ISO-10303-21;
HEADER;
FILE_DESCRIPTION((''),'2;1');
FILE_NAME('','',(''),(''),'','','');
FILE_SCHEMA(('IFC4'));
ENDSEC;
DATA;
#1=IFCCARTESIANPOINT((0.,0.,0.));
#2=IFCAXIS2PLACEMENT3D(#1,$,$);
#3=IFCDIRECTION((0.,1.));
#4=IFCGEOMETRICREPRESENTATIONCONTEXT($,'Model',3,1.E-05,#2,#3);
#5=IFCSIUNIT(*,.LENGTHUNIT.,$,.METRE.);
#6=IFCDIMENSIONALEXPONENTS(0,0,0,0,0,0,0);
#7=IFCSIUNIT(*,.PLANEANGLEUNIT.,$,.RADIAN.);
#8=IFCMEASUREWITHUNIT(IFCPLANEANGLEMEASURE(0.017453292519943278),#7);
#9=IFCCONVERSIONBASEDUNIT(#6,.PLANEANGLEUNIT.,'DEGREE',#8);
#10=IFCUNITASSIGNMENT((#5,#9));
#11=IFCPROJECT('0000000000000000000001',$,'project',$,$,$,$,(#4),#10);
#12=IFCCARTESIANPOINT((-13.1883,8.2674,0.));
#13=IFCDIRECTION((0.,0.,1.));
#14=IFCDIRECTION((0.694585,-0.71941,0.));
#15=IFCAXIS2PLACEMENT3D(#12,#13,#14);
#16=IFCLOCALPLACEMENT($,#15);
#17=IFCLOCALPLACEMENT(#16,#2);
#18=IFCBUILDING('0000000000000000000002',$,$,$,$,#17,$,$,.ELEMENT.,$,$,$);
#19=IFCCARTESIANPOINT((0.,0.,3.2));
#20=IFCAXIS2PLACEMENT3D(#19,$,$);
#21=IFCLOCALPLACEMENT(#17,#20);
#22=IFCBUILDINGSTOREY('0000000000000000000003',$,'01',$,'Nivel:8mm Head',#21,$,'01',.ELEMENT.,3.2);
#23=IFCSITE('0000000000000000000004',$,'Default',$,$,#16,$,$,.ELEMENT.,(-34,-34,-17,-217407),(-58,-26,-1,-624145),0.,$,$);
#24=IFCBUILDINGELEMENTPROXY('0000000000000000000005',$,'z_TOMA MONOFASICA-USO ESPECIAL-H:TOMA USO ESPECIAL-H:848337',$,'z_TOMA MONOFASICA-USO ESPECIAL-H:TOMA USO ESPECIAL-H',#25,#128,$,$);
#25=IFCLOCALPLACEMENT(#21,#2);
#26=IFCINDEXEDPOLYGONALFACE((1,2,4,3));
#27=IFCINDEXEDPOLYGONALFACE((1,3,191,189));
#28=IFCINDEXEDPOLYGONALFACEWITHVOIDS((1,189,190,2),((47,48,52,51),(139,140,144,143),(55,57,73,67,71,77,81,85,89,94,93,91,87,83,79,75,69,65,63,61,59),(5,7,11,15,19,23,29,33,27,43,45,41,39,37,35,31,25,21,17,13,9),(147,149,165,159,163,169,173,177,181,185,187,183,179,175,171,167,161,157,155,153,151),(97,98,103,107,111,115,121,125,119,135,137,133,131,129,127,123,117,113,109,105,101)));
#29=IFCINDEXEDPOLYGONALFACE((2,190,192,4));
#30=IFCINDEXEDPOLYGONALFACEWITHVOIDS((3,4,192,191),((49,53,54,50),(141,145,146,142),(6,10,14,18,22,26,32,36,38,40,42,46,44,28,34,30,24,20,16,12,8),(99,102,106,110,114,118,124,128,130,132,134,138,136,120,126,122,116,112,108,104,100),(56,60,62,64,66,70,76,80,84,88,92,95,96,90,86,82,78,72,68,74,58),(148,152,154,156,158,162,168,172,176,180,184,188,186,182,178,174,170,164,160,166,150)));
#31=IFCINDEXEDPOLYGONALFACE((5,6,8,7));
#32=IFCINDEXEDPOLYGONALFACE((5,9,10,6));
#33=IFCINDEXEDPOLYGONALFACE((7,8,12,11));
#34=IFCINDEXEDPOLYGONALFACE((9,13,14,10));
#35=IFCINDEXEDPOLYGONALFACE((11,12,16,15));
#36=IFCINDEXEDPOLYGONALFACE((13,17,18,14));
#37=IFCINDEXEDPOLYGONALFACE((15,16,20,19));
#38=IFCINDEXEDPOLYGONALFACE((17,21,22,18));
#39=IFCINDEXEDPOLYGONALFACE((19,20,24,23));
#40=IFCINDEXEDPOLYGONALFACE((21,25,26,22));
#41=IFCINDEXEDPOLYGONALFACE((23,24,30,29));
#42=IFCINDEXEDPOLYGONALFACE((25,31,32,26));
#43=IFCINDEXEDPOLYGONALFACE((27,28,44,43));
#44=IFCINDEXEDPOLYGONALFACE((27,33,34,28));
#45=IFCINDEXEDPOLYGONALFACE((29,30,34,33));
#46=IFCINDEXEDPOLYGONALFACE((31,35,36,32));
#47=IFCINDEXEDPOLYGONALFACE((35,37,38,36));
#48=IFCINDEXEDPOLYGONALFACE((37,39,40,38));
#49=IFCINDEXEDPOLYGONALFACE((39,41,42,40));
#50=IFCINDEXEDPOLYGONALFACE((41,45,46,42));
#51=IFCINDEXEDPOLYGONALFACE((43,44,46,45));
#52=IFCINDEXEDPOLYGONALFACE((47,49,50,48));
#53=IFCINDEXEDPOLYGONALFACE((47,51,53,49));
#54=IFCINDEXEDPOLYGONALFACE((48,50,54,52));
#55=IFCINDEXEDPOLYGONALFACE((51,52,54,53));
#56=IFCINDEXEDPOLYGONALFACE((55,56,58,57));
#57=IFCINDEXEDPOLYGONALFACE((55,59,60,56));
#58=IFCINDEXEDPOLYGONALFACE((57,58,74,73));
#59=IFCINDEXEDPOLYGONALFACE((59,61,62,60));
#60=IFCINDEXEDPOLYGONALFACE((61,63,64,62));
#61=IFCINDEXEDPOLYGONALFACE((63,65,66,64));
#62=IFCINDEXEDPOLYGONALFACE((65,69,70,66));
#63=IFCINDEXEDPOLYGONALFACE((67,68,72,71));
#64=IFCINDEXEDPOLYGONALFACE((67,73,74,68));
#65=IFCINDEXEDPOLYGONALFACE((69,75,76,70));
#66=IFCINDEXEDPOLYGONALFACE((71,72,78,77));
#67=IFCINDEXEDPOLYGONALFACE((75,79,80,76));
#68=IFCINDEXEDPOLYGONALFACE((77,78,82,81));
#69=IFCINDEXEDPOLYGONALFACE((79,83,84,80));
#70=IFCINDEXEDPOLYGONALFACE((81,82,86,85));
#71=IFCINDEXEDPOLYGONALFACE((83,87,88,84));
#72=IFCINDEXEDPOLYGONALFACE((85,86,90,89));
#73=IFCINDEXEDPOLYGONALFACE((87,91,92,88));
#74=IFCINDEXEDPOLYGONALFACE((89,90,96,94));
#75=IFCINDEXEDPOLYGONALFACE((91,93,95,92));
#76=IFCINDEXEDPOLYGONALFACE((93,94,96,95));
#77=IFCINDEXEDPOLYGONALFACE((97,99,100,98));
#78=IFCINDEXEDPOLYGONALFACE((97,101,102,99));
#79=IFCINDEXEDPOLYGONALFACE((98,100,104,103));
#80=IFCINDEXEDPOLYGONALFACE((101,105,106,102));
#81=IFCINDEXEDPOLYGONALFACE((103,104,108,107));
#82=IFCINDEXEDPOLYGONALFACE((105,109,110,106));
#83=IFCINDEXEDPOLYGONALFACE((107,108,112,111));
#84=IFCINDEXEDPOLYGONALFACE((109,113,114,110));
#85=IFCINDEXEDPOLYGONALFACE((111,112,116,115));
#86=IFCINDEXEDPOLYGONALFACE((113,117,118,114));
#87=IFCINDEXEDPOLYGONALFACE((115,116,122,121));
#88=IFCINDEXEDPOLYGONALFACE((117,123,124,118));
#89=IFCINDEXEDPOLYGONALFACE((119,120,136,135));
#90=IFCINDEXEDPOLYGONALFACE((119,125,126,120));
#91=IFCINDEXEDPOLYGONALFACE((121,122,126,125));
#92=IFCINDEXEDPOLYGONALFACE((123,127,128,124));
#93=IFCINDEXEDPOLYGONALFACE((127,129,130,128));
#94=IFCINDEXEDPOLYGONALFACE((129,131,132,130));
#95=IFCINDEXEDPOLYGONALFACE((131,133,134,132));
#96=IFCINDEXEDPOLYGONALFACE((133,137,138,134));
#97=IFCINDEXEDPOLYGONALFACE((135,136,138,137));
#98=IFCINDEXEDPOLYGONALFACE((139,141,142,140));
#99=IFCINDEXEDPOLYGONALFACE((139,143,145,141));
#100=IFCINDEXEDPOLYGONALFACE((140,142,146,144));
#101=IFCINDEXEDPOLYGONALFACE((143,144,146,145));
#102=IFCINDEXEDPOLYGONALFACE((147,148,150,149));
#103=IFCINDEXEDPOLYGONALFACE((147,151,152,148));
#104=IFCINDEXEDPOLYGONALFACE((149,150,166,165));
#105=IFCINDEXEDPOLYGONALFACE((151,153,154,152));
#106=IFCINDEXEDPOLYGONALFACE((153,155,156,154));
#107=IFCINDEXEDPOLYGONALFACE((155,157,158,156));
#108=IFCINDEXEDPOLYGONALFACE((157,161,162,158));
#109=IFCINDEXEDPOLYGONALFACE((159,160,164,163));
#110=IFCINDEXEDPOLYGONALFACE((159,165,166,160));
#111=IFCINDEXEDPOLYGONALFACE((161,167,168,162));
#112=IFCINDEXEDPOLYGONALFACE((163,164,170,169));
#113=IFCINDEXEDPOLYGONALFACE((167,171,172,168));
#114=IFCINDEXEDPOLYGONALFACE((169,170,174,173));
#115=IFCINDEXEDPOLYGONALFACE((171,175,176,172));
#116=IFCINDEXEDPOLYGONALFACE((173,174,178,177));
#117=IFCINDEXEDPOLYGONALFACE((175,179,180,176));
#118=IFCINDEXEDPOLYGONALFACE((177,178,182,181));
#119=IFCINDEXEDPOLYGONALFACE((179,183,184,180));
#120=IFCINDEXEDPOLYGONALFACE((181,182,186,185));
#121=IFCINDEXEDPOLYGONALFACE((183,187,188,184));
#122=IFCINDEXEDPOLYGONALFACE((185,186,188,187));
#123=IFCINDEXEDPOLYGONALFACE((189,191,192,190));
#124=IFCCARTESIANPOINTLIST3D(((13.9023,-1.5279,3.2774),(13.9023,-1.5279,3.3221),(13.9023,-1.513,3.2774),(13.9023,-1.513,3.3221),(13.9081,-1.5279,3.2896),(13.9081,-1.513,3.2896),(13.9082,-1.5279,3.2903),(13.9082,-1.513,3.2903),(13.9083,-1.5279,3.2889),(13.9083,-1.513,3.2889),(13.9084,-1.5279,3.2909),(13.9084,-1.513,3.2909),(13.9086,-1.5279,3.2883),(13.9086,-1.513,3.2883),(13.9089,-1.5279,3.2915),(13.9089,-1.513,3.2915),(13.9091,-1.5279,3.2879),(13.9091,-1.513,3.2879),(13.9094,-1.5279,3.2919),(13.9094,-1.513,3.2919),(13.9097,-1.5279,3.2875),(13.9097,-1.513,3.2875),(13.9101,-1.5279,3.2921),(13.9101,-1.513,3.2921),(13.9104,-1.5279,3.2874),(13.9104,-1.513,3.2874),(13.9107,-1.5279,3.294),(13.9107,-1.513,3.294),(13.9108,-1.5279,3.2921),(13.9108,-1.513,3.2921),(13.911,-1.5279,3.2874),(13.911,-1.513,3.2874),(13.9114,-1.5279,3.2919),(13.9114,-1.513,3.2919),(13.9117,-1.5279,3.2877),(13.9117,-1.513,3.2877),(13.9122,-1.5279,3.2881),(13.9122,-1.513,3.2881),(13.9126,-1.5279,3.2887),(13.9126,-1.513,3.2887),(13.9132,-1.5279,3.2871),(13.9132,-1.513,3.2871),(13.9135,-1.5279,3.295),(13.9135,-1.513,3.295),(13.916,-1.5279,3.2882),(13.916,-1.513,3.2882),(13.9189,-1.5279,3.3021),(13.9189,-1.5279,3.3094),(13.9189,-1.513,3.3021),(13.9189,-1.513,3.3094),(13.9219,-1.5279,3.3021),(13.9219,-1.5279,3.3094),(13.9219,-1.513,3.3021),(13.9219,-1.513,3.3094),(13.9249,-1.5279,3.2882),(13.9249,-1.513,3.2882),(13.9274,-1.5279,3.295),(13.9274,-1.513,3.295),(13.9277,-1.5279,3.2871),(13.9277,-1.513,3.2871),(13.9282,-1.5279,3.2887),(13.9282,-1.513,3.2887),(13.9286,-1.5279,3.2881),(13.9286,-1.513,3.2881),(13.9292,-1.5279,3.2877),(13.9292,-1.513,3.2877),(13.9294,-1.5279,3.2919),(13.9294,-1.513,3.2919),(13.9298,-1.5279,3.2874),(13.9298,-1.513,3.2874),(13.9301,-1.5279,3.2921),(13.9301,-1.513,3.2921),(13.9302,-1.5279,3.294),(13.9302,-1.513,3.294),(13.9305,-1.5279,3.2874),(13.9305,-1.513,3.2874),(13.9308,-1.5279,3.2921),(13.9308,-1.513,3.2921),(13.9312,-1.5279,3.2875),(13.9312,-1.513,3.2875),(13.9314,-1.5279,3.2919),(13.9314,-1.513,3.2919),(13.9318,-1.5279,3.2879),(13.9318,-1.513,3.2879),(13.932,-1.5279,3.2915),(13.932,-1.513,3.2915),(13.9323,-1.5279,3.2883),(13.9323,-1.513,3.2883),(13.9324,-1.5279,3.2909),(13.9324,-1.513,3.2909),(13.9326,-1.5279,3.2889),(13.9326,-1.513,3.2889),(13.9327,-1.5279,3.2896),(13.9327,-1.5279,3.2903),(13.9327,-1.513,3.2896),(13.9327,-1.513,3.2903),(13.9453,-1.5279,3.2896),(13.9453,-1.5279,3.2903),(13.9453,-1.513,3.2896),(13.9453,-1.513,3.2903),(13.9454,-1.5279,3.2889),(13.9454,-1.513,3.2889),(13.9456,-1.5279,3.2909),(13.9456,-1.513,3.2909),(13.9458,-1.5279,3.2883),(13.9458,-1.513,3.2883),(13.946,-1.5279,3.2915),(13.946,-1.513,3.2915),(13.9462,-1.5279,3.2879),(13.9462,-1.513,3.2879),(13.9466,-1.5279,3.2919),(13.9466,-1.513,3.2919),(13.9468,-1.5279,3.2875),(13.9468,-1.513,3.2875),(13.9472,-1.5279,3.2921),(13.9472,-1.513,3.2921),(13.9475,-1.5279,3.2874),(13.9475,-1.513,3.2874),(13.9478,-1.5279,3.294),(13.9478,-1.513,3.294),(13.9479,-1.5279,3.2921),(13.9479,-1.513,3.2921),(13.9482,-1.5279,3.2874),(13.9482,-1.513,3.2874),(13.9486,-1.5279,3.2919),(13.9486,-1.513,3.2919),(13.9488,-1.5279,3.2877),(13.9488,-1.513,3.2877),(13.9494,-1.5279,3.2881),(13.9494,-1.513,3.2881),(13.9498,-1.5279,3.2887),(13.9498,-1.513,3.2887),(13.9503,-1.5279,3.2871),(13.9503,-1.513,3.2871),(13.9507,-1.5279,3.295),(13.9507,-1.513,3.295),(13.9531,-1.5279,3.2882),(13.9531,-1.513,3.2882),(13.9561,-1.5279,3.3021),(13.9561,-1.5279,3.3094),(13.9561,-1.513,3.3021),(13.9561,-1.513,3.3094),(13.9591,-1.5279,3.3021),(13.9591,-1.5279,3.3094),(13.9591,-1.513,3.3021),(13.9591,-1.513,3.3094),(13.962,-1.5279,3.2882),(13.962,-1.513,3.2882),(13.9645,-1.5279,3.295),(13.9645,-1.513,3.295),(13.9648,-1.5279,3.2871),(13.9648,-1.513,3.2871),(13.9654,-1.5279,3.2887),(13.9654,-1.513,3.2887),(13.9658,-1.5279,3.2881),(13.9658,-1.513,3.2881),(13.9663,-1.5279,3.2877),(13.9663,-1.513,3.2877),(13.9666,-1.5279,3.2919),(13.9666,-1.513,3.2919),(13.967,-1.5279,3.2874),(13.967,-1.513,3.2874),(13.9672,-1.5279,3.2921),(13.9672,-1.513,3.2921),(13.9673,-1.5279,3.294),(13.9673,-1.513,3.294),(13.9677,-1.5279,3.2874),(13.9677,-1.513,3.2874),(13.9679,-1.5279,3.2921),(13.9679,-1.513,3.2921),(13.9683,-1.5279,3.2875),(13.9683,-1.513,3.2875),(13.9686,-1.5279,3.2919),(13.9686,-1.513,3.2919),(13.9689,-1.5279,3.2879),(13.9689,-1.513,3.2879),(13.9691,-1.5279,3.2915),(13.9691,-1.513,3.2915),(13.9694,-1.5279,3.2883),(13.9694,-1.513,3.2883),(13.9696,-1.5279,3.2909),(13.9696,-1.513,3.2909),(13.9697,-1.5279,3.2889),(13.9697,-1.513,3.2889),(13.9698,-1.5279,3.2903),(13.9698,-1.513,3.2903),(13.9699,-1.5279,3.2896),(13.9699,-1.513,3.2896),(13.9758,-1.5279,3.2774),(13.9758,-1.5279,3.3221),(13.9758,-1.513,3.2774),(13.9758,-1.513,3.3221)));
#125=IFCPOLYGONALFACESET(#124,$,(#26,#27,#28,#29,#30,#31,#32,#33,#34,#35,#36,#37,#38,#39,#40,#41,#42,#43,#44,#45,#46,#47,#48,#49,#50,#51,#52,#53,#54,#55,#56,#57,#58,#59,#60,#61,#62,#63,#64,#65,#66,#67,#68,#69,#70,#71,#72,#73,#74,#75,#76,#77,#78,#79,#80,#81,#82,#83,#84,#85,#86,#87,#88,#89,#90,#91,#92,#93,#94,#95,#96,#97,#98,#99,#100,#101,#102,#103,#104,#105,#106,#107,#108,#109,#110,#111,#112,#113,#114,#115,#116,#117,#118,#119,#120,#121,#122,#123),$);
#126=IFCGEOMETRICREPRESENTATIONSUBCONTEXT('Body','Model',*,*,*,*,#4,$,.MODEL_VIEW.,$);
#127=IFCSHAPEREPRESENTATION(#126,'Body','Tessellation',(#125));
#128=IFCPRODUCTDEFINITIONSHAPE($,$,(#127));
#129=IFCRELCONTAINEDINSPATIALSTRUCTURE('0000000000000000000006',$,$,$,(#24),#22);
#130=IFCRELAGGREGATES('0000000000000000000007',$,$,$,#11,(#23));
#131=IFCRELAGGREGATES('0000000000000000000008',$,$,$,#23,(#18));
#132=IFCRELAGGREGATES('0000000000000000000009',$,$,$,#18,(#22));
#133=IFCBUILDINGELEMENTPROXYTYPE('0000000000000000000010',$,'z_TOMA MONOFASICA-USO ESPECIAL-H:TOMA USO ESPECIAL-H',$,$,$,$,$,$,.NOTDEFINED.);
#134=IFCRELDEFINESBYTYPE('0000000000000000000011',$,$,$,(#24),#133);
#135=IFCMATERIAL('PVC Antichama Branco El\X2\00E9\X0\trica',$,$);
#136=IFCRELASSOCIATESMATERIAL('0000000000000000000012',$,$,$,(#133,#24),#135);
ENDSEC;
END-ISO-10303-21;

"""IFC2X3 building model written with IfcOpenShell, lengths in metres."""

from ifc_helpers import new_model, entity, si_unit, converted_unit, direction, frame, frame_2d, origin, place, context, subcontext, project, spatial, polyline, circle_curve, parameter, trimmed, segment, composite_curve, outline, extrude, source, transform, mapped, material, type_object, type_shapes, element, save


model = new_model("IFC2X3")

# Units and contexts
model_context = context("Model", 3, precision=1e-05, world=origin(), true_north=direction((0.0, 1.0)))
body_context = subcontext(model_context, "Body", "Model", "MODEL_VIEW")
ifc_project = project(units=[si_unit("LENGTHUNIT", "METRE"), converted_unit("PLANEANGLEUNIT", "DEGREE", entity("IfcPlaneAngleMeasure", 0.017453292519943278), si_unit("PLANEANGLEUNIT", "RADIAN"), dimensions=[0, 0, 0, 0, 0, 0, 0])], contexts=[model_context])

# Site, building, storey
site_placement = place(None, frame((-13.1883, 8.2674, 0.0), z_axis=(0.0, 0.0, 1.0), x_axis=(0.694585, -0.71941, 0.0)))
site = spatial("IfcSite", under=ifc_project, at=site_placement, Name="Default", CompositionType="ELEMENT", RefLatitude=(-34, -34, -17, -217407), RefLongitude=(-58, -26, -1, -624145), RefElevation=0.0)
building_placement = place(site_placement, origin())
building = spatial("IfcBuilding", under=site, at=building_placement, CompositionType="ELEMENT")
storey_placement = place(building_placement, frame((0.0, 0.0, 3.2)))
storey = spatial("IfcBuildingStorey", under=building, at=storey_placement, Name="01", ObjectType="Nivel:8mm Head", LongName="01", CompositionType="ELEMENT", Elevation=3.2)

# Building element proxy
ifc_material_1 = material(Name="PVC Antichama Branco Elétrica")
building_element_proxy_type_1 = type_object("IfcBuildingElementProxyType", Name="z_TOMA MONOFASICA-USO ESPECIAL-H:TOMA USO ESPECIAL-H", PredefinedType="NOTDEFINED", material=ifc_material_1)
shared_shape_1 = source(origin(), body_context, "Body", "SweptSolid", [
    extrude(outline(polyline([(-0.0368, -0.0223), (0.0368, -0.0223), (0.0368, 0.0223), (-0.0368, 0.0223), (-0.0368, -0.0223)]), holes=[composite_curve([segment(polyline([(0.0141, 0.0115), (0.0116, 0.0047)]), True, "CONTINUOUS"), segment(polyline([(0.0116, 0.0047), (0.0088, 0.0057)]), True, "CONTINUOUS"), segment(polyline([(0.0088, 0.0057), (0.0096, 0.0078)]), True, "CONTINUOUS"), segment(trimmed(circle_curve(frame_2d((0.0087, 0.0099), x_axis=(1.0, 0.0)), 0.0024), [parameter(27.118901)], [parameter(292.881099)], True, "PARAMETER"), False, "CONTINUOUS"), segment(polyline([(0.0108, 0.011), (0.0113, 0.0126)]), True, "CONTINUOUS"), segment(polyline([(0.0113, 0.0126), (0.0141, 0.0115)]), True, "CONTINUOUS")], self_intersect=False), composite_curve([segment(polyline([(0.0255, 0.0047), (0.023, 0.0115)]), True, "CONTINUOUS"), segment(polyline([(0.023, 0.0115), (0.0258, 0.0126)]), True, "CONTINUOUS"), segment(polyline([(0.0258, 0.0126), (0.0264, 0.011)]), True, "CONTINUOUS"), segment(trimmed(circle_curve(frame_2d((0.0285, 0.0099), x_axis=(1.0, 0.0)), 0.0024), [parameter(247.118901)], [parameter(152.881099)], True, "PARAMETER"), False, "CONTINUOUS"), segment(polyline([(0.0276, 0.0078), (0.0283, 0.0057)]), True, "CONTINUOUS"), segment(polyline([(0.0283, 0.0057), (0.0255, 0.0047)]), True, "CONTINUOUS")], self_intersect=False), polyline([(0.0201, -0.0024), (0.0201, -0.0097), (0.0171, -0.0097), (0.0171, -0.0024), (0.0201, -0.0024)]), composite_curve([segment(polyline([(-0.0141, 0.0115), (-0.0113, 0.0126)]), True, "CONTINUOUS"), segment(polyline([(-0.0113, 0.0126), (-0.0108, 0.011)]), True, "CONTINUOUS"), segment(trimmed(circle_curve(frame_2d((-0.0087, 0.0099), x_axis=(1.0, 0.0)), 0.0024), [parameter(247.118901)], [parameter(152.881099)], True, "PARAMETER"), False, "CONTINUOUS"), segment(polyline([(-0.0096, 0.0078), (-0.0088, 0.0057)]), True, "CONTINUOUS"), segment(polyline([(-0.0088, 0.0057), (-0.0116, 0.0047)]), True, "CONTINUOUS"), segment(polyline([(-0.0116, 0.0047), (-0.0141, 0.0115)]), True, "CONTINUOUS")], self_intersect=False), composite_curve([segment(polyline([(-0.0255, 0.0047), (-0.0283, 0.0057)]), True, "CONTINUOUS"), segment(polyline([(-0.0283, 0.0057), (-0.0276, 0.0078)]), True, "CONTINUOUS"), segment(trimmed(circle_curve(frame_2d((-0.0285, 0.0099), x_axis=(1.0, 0.0)), 0.0024), [parameter(27.118901)], [parameter(292.881099)], True, "PARAMETER"), False, "CONTINUOUS"), segment(polyline([(-0.0264, 0.011), (-0.0258, 0.0126)]), True, "CONTINUOUS"), segment(polyline([(-0.0258, 0.0126), (-0.023, 0.0115)]), True, "CONTINUOUS"), segment(polyline([(-0.023, 0.0115), (-0.0255, 0.0047)]), True, "CONTINUOUS")], self_intersect=False), polyline([(-0.0201, -0.0024), (-0.0171, -0.0024), (-0.0171, -0.0097), (-0.0201, -0.0097), (-0.0201, -0.0024)])]), frame((0.0, -0.005, 0.0223), z_axis=(0.0, 1.0, 0.0), x_axis=(1.0, 0.0, 0.0)), (0.0, 0.0, 1.0), 0.0148),
])
type_shapes(building_element_proxy_type_1, [shared_shape_1])
for number, where, name in (
    (1, (13.939, -1.5229, 3.2774), "z_TOMA MONOFASICA-USO ESPECIAL-H:TOMA USO ESPECIAL-H:848337"),
):
    element("IfcBuildingElementProxy", number, at=place(storey_placement, frame(where)), inside=storey, type_object=building_element_proxy_type_1, material=ifc_material_1, Name=name, ObjectType="z_TOMA MONOFASICA-USO ESPECIAL-H:TOMA USO ESPECIAL-H", context=body_context, shape_type="MappedRepresentation", body=[
        mapped(shared_shape_1, transform((0.0, 0.0, 0.0), scale=1.0)),
    ])

save(model, "model.ifc")
